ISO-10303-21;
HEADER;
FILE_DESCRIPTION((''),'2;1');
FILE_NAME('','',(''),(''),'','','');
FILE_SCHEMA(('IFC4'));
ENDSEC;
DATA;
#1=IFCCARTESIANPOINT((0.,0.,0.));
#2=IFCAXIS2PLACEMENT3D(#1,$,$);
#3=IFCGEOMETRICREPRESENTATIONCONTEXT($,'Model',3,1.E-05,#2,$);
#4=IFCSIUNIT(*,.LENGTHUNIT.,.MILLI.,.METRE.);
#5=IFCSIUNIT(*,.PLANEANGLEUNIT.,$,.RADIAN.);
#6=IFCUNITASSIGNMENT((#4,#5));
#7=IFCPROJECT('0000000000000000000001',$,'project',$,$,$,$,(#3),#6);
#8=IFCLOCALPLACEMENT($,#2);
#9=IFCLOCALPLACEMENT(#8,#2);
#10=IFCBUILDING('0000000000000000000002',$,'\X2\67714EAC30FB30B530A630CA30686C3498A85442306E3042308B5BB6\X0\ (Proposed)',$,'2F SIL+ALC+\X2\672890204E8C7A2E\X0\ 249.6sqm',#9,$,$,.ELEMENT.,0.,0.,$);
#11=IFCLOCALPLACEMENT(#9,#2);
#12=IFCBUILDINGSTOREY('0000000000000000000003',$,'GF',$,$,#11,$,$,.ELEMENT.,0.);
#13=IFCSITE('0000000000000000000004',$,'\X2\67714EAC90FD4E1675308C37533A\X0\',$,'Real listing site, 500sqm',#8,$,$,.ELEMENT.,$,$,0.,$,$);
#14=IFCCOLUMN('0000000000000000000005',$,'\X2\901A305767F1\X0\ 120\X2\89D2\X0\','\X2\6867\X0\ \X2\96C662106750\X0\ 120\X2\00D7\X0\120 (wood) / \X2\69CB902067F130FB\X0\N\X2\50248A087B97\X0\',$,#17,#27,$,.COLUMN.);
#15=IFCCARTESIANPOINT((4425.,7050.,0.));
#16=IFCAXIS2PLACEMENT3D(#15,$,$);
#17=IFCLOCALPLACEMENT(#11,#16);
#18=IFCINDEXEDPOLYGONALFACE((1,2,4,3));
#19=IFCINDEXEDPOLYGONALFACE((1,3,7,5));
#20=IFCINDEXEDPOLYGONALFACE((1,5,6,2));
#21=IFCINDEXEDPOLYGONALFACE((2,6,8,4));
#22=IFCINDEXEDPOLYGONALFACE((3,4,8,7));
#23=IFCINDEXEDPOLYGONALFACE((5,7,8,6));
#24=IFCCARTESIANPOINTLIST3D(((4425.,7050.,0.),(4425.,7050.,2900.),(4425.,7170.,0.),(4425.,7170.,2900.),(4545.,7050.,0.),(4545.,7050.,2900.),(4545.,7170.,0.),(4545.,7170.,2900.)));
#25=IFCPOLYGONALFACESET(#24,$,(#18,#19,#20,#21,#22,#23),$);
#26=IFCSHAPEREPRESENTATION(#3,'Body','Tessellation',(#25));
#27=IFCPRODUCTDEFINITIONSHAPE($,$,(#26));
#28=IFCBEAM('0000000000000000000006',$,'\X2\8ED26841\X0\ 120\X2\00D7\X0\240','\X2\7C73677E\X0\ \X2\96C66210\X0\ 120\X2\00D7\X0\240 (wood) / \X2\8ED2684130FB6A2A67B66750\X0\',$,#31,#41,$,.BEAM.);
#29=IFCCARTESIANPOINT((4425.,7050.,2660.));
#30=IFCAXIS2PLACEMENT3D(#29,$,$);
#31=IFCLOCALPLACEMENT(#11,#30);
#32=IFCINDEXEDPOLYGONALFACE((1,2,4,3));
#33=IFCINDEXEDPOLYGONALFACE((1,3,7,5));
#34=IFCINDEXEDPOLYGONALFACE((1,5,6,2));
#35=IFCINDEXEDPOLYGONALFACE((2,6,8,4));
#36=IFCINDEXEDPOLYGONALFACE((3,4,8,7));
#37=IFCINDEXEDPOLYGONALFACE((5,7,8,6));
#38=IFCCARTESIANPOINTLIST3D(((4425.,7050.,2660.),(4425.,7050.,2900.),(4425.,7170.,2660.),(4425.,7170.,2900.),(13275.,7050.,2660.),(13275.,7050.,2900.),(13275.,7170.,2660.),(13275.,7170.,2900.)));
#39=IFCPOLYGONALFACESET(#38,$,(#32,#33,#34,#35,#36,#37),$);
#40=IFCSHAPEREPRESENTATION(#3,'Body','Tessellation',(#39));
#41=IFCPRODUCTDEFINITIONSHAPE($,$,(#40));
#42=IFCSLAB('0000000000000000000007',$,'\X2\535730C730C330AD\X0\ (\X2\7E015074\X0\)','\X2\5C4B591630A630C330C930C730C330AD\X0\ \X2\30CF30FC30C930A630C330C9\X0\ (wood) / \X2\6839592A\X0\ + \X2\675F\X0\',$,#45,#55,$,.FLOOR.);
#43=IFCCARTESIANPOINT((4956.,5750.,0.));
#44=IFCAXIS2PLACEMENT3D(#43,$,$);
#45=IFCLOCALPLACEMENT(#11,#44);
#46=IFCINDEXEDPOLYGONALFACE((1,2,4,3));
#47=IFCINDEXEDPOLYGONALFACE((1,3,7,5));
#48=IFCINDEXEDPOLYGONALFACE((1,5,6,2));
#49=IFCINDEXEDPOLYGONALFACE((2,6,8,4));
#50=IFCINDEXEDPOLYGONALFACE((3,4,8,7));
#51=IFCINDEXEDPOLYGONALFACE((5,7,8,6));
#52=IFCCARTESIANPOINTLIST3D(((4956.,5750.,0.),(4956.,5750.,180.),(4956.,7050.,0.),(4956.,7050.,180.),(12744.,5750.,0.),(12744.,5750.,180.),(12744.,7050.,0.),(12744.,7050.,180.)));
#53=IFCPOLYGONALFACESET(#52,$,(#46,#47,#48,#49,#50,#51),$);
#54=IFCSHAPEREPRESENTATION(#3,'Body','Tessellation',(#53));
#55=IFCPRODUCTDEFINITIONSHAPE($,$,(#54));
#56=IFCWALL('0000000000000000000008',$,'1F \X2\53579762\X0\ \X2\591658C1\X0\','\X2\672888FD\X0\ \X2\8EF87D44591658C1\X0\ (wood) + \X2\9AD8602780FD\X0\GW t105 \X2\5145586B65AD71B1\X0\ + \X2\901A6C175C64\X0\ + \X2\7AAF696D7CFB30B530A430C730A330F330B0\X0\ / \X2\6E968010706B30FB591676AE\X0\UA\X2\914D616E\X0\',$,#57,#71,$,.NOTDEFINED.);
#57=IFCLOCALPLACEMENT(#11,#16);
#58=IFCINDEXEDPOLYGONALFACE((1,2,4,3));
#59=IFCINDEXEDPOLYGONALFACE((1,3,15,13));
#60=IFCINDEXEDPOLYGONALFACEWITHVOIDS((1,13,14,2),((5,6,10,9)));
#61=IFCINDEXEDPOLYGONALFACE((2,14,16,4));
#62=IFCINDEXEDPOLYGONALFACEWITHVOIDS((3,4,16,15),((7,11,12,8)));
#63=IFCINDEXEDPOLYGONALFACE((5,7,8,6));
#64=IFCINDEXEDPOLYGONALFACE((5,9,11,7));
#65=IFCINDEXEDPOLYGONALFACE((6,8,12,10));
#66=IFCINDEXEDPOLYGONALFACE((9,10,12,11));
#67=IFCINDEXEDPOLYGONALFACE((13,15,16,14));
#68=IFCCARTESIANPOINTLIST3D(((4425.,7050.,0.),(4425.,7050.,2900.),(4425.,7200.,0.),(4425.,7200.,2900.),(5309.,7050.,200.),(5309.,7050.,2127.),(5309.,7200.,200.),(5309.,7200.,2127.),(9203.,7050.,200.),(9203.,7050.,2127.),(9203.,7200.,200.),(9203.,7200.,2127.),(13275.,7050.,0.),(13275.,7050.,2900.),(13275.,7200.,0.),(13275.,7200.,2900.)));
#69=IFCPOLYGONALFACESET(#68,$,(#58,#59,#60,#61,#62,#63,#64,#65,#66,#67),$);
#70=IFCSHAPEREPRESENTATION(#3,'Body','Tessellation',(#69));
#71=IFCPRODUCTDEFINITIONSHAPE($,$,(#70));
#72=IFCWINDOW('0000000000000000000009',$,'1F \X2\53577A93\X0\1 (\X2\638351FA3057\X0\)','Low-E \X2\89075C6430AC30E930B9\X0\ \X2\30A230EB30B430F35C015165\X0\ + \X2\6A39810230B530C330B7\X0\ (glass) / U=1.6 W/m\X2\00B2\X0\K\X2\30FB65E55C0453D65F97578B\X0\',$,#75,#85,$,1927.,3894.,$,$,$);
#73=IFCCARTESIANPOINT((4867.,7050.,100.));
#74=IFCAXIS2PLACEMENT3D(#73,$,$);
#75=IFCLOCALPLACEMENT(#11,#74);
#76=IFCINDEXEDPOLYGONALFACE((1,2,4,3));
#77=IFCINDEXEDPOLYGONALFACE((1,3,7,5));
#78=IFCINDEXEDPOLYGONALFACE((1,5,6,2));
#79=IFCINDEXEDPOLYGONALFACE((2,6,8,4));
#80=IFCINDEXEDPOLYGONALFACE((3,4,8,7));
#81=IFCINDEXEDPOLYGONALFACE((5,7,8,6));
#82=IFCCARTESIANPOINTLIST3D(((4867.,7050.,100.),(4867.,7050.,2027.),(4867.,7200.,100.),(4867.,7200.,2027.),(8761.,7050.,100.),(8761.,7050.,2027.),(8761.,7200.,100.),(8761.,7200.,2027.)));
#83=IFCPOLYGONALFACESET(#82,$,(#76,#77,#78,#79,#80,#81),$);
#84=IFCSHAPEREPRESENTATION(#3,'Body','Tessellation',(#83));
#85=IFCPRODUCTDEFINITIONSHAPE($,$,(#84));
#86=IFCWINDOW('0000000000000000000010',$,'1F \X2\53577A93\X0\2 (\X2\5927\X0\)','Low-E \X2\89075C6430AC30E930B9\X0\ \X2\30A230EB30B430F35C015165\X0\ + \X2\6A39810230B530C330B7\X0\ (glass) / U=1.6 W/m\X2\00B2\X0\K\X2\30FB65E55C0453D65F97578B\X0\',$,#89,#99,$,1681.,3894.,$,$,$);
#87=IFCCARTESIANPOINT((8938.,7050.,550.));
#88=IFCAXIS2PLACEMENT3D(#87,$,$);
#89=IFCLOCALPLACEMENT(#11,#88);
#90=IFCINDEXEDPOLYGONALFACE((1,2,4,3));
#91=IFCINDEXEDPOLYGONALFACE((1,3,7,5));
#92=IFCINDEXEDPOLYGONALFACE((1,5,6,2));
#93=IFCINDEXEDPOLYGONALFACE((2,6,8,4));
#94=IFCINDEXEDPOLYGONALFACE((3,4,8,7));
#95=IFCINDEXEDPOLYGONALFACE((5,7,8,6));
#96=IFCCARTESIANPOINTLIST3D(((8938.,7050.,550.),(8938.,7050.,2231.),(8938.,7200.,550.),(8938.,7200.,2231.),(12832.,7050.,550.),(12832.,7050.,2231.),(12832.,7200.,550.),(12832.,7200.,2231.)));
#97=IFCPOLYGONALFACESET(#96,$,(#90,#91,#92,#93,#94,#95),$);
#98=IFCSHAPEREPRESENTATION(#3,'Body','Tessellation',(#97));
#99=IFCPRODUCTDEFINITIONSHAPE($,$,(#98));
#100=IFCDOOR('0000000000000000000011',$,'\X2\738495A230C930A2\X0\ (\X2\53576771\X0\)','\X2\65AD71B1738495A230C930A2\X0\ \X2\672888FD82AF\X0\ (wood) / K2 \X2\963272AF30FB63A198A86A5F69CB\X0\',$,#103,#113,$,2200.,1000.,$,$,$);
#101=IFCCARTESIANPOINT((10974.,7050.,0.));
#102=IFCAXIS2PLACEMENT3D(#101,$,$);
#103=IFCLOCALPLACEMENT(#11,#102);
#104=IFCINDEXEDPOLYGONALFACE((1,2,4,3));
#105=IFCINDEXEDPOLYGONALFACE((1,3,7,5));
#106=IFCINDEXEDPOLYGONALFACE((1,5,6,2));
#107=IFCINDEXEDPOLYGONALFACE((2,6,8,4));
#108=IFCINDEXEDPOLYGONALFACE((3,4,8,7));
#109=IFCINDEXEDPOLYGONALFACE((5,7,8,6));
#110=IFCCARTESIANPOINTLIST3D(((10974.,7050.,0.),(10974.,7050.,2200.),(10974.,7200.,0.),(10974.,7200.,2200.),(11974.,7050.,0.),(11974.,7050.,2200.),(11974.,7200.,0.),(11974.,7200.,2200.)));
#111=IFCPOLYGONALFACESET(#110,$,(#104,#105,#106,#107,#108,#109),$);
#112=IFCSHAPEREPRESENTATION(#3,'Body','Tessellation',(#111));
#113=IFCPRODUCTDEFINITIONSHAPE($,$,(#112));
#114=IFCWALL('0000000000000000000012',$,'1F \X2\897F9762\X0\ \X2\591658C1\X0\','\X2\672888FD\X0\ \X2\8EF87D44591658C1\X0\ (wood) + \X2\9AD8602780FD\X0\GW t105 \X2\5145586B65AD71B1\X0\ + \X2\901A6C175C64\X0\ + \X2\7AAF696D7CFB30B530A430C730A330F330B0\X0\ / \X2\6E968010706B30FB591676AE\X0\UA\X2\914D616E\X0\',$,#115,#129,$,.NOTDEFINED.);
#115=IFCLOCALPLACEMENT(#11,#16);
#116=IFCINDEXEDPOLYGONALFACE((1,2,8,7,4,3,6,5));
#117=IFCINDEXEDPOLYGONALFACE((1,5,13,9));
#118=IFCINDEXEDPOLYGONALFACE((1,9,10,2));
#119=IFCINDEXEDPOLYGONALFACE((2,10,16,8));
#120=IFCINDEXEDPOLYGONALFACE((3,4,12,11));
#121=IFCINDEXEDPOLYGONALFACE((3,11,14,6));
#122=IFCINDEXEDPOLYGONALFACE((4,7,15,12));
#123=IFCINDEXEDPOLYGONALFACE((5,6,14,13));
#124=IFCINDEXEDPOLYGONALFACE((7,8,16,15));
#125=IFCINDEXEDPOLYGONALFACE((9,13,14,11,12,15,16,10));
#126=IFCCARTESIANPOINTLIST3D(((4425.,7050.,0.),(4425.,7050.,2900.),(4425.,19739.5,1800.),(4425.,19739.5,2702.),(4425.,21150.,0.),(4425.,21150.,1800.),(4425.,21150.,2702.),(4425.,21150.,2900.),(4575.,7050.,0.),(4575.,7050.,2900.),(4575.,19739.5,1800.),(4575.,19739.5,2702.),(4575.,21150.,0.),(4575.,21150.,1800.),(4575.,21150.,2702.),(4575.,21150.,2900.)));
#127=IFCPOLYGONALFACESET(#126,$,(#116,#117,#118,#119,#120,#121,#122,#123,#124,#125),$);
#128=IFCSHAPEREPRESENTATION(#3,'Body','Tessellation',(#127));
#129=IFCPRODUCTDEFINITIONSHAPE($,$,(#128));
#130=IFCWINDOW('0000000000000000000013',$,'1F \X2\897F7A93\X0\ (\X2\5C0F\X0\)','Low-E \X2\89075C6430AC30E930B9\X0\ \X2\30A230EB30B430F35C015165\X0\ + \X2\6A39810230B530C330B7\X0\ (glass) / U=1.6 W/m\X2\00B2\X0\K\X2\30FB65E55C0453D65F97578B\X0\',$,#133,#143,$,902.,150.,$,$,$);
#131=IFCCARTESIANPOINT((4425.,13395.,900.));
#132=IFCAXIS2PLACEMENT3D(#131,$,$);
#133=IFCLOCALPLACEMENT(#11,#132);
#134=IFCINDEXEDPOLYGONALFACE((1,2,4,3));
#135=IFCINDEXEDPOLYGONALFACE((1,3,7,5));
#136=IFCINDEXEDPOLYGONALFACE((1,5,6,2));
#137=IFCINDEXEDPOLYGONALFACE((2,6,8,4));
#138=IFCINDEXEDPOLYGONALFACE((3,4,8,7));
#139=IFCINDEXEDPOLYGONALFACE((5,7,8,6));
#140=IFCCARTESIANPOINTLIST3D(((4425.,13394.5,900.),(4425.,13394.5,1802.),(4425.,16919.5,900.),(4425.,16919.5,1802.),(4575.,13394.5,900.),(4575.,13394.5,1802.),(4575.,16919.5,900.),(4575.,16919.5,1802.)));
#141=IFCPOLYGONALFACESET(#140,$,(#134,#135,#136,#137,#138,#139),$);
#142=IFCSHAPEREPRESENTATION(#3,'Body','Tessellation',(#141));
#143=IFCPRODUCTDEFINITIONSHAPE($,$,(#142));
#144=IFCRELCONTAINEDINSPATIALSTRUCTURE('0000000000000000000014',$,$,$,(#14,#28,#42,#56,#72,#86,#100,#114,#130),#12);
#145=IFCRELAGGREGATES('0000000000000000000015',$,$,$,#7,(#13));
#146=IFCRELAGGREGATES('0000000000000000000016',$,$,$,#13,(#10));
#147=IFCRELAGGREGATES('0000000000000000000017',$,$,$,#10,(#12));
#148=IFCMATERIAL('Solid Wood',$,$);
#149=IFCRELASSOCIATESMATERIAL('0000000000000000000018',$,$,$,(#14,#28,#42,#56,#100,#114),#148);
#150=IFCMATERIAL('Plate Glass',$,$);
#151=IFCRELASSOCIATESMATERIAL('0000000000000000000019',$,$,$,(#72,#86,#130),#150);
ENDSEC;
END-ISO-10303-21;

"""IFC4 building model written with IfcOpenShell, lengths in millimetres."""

from ifc_helpers import new_model, si_unit, frame, frame_2d, origin, place, context, project, spatial, rectangle, extrude, material, element, fill, save


model = new_model("IFC4")

# Units and contexts
model_context = context("Model", 3, precision=1e-05, world=origin())
ifc_project = project(units=[si_unit("LENGTHUNIT", "METRE", prefix="MILLI"), si_unit("PLANEANGLEUNIT", "RADIAN")], contexts=[model_context])

# Site, building, storey
site_placement = place(None, origin())
site = spatial("IfcSite", under=ifc_project, at=site_placement, Name="東京都世田谷区", ObjectType="Real listing site, 500sqm", CompositionType="ELEMENT", RefElevation=0.0)
building_placement = place(site_placement, origin())
building = spatial("IfcBuilding", under=site, at=building_placement, Name="東京・サウナと水風呂のある家 (Proposed)", ObjectType="2F SIL+ALC+木造二種 249.6sqm", CompositionType="ELEMENT", ElevationOfRefHeight=0.0, ElevationOfTerrain=0.0)
storey_placement = place(building_placement, origin())
storey = spatial("IfcBuildingStorey", under=building, at=storey_placement, Name="GF", CompositionType="ELEMENT", Elevation=0.0)

# Column
ifc_material_1 = material(Name="Solid Wood")
column_placement = place(storey_placement, frame((4425.0, 7050.0, 0.0)))
element("IfcColumn", 1, at=column_placement, inside=storey, material=ifc_material_1, Name="通し柱 120角", Description="桧 集成材 120×120 (wood) / 構造柱・N値計算", PredefinedType="COLUMN", context=model_context, shape_type="SweptSolid", body=[
    extrude(rectangle(XDim=120.0, YDim=120.0, at=frame_2d((60.0, 60.0))), frame((4425.0, 7050.0, 0.0)), (0.0, 0.0, 1.0), 2900.0),
])

# Beam
beam_1_placement = place(storey_placement, frame((4425.0, 7050.0, 2660.0)))
element("IfcBeam", 2, at=beam_1_placement, inside=storey, material=ifc_material_1, Name="軒桁 120×240", Description="米松 集成 120×240 (wood) / 軒桁・横架材", PredefinedType="BEAM", context=model_context, shape_type="SweptSolid", body=[
    extrude(rectangle(XDim=8850.0, YDim=120.0, at=frame_2d((4425.0, 60.0))), frame((4425.0, 7050.0, 2660.0)), (0.0, 0.0, 1.0), 240.0),
])

# Slab
slab_1_placement = place(storey_placement, frame((4956.0, 5750.0, 0.0)))
element("IfcSlab", 3, at=slab_1_placement, inside=storey, material=ifc_material_1, Name="南デッキ (縁側)", Description="屋外ウッドデッキ ハードウッド (wood) / 根太 + 束", PredefinedType="FLOOR", context=model_context, shape_type="SweptSolid", body=[
    extrude(rectangle(XDim=7788.0, YDim=1300.0, at=frame_2d((3894.0, 650.0))), frame((4956.0, 5750.0, 0.0)), (0.0, 0.0, 1.0), 180.0),
])

# Wall, openings, windows, door
wall_1_placement = place(storey_placement, frame((4425.0, 7050.0, 0.0)))
wall_1 = element("IfcWall", 4, at=wall_1_placement, inside=storey, material=ifc_material_1, Name="1F 南面 外壁", Description="木製 軸組外壁 (wood) + 高性能GW t105 充填断熱 + 通気層 + 窯業系サイディング / 準耐火・外皮UA配慮", PredefinedType="NOTDEFINED", context=model_context, shape_type="SweptSolid", body=[
    extrude(rectangle(XDim=8850.0, YDim=150.0, at=frame_2d((4425.0, 75.0))), frame((4425.0, 7050.0, 0.0)), (0.0, 0.0, 1.0), 2900.0),
])
opening_1_placement = place(storey_placement, frame((4867.0, 7050.0, 100.0)))
opening_1 = element("IfcOpeningElement", 5, at=opening_1_placement, cuts=wall_1, PredefinedType="NOTDEFINED", context=model_context, shape_type="SweptSolid", body=[
    extrude(rectangle(XDim=3894.0, YDim=150.0, at=frame_2d((1947.0, 75.0))), frame((4867.0, 7050.0, 100.0)), (0.0, 0.0, 1.0), 1927.0),
])
opening_2_placement = place(storey_placement, frame((8938.0, 7050.0, 550.0)))
opening_2 = element("IfcOpeningElement", 6, at=opening_2_placement, cuts=wall_1, PredefinedType="NOTDEFINED", context=model_context, shape_type="SweptSolid", body=[
    extrude(rectangle(XDim=3894.0, YDim=150.0, at=frame_2d((1947.0, 75.0))), frame((8938.0, 7050.0, 550.0)), (0.0, 0.0, 1.0), 1681.0),
])
opening_3_placement = place(storey_placement, frame((10974.0, 7050.0, 0.0)))
opening_3 = element("IfcOpeningElement", 7, at=opening_3_placement, cuts=wall_1, PredefinedType="NOTDEFINED", context=model_context, shape_type="SweptSolid", body=[
    extrude(rectangle(XDim=1000.0, YDim=150.0, at=frame_2d((500.0, 75.0))), frame((10974.0, 7050.0, 0.0)), (0.0, 0.0, 1.0), 2200.0),
])
ifc_material_2 = material(Name="Plate Glass")
window_1_placement = place(storey_placement, frame((4867.0, 7050.0, 100.0)))
window_1 = element("IfcWindow", 8, at=window_1_placement, inside=storey, material=ifc_material_2, Name="1F 南窓1 (掃出し)", Description="Low-E 複層ガラス アルゴン封入 + 樹脂サッシ (glass) / U=1.6 W/m²K・日射取得型", OverallHeight=1927.0, OverallWidth=3894.0, context=model_context, shape_type="SweptSolid", body=[
    extrude(rectangle(XDim=3894.0, YDim=150.0, at=frame_2d((1947.0, 75.0))), frame((4867.0, 7050.0, 100.0)), (0.0, 0.0, 1.0), 1927.0),
])
fill(opening_1, window_1)
window_2_placement = place(storey_placement, frame((8938.0, 7050.0, 550.0)))
window_2 = element("IfcWindow", 9, at=window_2_placement, inside=storey, material=ifc_material_2, Name="1F 南窓2 (大)", Description="Low-E 複層ガラス アルゴン封入 + 樹脂サッシ (glass) / U=1.6 W/m²K・日射取得型", OverallHeight=1681.0, OverallWidth=3894.0, context=model_context, shape_type="SweptSolid", body=[
    extrude(rectangle(XDim=3894.0, YDim=150.0, at=frame_2d((1947.0, 75.0))), frame((8938.0, 7050.0, 550.0)), (0.0, 0.0, 1.0), 1681.0),
])
fill(opening_2, window_2)
door_placement = place(storey_placement, frame((10974.0, 7050.0, 0.0)))
door = element("IfcDoor", 10, at=door_placement, inside=storey, material=ifc_material_1, Name="玄関ドア (南東)", Description="断熱玄関ドア 木製芯 (wood) / K2 防犯・採風機構", OverallHeight=2200.0, OverallWidth=1000.0, context=model_context, shape_type="SweptSolid", body=[
    extrude(rectangle(XDim=1000.0, YDim=150.0, at=frame_2d((500.0, 75.0))), frame((10974.0, 7050.0, 0.0)), (0.0, 0.0, 1.0), 2200.0),
])
fill(opening_3, door)

# Wall, opening, window
wall_2_placement = place(storey_placement, frame((4425.0, 7050.0, 0.0)))
wall_2 = element("IfcWall", 11, at=wall_2_placement, inside=storey, material=ifc_material_1, Name="1F 西面 外壁", Description="木製 軸組外壁 (wood) + 高性能GW t105 充填断熱 + 通気層 + 窯業系サイディング / 準耐火・外皮UA配慮", PredefinedType="NOTDEFINED", context=model_context, shape_type="SweptSolid", body=[
    extrude(rectangle(XDim=150.0, YDim=14100.0, at=frame_2d((75.0, 7050.0))), frame((4425.0, 7050.0, 0.0)), (0.0, 0.0, 1.0), 2900.0),
])
opening_4_placement = place(storey_placement, frame((4425.0, 13395.0, 900.0)))
opening_4 = element("IfcOpeningElement", 12, at=opening_4_placement, cuts=wall_2, PredefinedType="NOTDEFINED", context=model_context, shape_type="SweptSolid", body=[
    extrude(rectangle(XDim=150.0, YDim=3525.0, at=frame_2d((75.0, 1762.0))), frame((4425.0, 13395.0, 900.0)), (0.0, 0.0, 1.0), 902.0),
])
window_3_placement = place(storey_placement, frame((4425.0, 13395.0, 900.0)))
window_3 = element("IfcWindow", 13, at=window_3_placement, inside=storey, material=ifc_material_2, Name="1F 西窓 (小)", Description="Low-E 複層ガラス アルゴン封入 + 樹脂サッシ (glass) / U=1.6 W/m²K・日射取得型", OverallHeight=902.0, OverallWidth=150.0, context=model_context, shape_type="SweptSolid", body=[
    extrude(rectangle(XDim=150.0, YDim=3525.0, at=frame_2d((75.0, 1762.0))), frame((4425.0, 13395.0, 900.0)), (0.0, 0.0, 1.0), 902.0),
])
fill(opening_4, window_3)

save(model, "model.ifc")
